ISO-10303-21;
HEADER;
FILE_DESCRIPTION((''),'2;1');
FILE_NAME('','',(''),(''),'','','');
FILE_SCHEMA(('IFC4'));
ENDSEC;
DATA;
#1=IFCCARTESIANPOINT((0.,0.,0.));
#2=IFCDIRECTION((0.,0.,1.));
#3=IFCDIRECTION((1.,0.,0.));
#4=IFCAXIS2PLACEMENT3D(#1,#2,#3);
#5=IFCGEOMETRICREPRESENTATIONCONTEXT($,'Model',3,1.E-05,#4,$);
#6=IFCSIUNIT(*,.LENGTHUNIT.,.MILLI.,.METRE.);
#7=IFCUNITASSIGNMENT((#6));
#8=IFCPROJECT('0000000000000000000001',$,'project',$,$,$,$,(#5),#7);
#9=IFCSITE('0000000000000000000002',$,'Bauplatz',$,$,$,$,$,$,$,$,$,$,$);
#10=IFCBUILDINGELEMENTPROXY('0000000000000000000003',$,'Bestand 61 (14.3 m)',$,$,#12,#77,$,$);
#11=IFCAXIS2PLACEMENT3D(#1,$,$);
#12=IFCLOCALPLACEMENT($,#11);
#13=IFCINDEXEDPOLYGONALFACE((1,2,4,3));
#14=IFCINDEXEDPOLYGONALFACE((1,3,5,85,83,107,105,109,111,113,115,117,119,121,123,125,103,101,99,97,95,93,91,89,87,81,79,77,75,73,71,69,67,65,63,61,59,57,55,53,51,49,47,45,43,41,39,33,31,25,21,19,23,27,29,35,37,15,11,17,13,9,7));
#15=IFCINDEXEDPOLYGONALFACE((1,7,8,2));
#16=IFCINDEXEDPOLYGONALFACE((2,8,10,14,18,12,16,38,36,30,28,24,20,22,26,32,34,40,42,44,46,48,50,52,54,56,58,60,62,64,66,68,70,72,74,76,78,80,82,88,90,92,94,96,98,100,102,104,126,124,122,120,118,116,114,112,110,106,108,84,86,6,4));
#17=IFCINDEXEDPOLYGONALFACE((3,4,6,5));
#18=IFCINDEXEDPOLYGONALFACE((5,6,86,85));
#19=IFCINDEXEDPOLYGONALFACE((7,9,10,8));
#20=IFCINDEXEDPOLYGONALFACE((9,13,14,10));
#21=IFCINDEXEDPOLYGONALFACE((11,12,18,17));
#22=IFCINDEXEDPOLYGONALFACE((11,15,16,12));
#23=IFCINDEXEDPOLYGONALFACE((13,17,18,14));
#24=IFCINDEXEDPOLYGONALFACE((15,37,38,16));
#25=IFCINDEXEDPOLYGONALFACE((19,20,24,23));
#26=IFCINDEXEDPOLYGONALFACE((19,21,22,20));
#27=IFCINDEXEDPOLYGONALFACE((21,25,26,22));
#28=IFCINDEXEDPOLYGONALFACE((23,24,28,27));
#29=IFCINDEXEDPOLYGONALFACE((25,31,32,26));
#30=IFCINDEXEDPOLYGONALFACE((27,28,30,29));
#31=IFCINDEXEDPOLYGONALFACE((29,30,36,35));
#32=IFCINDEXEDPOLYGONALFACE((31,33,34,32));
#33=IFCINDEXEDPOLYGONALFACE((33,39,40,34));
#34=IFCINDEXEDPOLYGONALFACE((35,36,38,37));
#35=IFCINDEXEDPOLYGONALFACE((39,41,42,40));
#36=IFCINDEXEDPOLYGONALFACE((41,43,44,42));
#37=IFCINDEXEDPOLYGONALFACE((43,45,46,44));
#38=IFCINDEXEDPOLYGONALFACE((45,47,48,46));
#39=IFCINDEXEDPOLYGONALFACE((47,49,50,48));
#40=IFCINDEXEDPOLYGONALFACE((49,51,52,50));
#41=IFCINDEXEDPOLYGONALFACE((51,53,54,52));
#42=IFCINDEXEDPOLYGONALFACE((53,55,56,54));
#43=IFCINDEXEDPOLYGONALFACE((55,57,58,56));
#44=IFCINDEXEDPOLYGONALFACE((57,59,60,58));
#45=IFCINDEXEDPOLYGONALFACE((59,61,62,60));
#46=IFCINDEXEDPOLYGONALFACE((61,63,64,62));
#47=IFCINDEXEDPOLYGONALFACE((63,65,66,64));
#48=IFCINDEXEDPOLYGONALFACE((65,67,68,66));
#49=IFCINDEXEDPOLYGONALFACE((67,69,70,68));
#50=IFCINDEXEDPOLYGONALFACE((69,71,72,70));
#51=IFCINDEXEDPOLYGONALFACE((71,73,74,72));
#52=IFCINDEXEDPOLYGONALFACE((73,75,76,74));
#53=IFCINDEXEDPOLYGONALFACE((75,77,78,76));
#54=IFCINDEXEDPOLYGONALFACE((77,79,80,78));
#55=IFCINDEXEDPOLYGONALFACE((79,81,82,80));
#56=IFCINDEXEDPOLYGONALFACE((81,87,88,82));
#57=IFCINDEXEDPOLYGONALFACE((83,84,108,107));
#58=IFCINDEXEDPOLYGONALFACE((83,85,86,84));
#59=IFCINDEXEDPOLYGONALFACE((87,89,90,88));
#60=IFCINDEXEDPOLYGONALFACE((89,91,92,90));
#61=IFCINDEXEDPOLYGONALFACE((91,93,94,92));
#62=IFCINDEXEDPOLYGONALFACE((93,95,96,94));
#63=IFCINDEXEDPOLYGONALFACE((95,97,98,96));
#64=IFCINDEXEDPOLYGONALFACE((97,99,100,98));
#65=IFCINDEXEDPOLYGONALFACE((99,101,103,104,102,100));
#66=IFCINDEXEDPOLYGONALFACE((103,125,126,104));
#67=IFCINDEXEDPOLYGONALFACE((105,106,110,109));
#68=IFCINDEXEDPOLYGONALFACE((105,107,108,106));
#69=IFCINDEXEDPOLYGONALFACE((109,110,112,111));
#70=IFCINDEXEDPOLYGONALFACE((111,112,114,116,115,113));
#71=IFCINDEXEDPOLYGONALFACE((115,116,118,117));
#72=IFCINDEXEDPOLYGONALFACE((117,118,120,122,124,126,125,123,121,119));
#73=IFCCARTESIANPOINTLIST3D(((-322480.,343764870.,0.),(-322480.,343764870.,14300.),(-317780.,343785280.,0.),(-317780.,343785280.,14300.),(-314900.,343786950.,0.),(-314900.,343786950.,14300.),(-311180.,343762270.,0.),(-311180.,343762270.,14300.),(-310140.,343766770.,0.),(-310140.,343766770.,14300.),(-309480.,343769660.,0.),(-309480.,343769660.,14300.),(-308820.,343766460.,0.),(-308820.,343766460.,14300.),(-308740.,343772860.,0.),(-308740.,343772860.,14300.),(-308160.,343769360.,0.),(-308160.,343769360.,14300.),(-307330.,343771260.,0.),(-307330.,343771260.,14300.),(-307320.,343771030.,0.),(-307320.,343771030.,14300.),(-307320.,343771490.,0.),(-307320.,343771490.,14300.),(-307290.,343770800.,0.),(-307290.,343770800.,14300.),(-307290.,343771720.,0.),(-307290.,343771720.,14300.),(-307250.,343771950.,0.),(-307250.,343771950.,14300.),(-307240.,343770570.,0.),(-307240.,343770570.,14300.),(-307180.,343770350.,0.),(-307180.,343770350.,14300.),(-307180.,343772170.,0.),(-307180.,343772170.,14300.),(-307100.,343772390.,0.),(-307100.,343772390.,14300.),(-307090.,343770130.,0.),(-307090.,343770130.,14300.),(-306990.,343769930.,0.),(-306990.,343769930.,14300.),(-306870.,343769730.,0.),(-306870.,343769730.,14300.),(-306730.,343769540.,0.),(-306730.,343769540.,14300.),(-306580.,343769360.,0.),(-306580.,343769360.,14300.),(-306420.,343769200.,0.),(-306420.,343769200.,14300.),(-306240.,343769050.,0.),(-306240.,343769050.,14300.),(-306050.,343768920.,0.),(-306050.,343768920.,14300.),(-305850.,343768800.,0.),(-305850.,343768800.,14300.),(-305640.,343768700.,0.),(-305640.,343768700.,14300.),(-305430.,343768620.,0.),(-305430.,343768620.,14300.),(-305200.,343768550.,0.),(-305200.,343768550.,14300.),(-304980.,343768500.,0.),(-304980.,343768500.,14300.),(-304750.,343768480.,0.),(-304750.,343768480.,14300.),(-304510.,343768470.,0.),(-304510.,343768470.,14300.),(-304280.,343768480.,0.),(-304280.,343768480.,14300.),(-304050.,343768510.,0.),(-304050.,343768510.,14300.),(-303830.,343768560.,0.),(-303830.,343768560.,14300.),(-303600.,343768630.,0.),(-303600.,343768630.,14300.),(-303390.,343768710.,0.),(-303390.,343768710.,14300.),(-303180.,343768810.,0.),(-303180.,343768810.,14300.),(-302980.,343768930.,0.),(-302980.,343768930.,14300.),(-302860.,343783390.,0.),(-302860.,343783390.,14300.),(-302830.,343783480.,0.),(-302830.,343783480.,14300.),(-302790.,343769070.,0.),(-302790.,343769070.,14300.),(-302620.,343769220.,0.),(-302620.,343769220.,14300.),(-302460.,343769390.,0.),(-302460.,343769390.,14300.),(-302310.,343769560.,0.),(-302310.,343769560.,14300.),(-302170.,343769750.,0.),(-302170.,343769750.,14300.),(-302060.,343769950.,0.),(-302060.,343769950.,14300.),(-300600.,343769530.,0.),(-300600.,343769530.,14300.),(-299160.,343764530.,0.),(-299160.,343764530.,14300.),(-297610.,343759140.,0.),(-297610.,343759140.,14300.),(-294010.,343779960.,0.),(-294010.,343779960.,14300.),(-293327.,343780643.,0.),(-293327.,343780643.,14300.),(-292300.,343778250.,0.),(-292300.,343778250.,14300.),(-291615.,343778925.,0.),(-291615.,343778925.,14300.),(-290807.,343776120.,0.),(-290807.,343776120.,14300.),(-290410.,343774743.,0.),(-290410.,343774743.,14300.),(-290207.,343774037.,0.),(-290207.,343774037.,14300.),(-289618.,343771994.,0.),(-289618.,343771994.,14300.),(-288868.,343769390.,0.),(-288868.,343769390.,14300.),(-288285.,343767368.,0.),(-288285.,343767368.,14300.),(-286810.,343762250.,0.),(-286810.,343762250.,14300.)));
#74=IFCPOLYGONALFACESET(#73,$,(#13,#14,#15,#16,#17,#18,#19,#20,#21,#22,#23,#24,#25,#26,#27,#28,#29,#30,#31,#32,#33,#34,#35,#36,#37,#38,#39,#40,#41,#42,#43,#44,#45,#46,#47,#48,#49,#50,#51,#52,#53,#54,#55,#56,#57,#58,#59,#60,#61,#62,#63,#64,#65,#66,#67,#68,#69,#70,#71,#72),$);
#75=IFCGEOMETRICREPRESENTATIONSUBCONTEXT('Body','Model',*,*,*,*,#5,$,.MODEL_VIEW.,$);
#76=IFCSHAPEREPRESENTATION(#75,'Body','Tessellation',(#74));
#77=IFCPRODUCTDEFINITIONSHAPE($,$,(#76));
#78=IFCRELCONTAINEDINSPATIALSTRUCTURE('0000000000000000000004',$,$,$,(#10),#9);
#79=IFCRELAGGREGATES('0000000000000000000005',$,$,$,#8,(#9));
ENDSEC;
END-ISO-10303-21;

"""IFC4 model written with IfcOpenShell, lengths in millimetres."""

from ifc_helpers import new_model, si_unit, origin_with_axes, place, context, subcontext, project, spatial, indexed_curve, outline, extrude, element, save


model = new_model("IFC4")

# Units and contexts
model_context = context("Model", 3, precision=1e-05, world=origin_with_axes())
body_context = subcontext(model_context, "Body", "Model", "MODEL_VIEW")
ifc_project = project(units=[si_unit("LENGTHUNIT", "METRE", prefix="MILLI")], contexts=[model_context])

# Site
site = spatial("IfcSite", under=ifc_project, Name="Bauplatz")

# Building element proxy
proxy_1_placement = place(None, origin_with_axes())
element("IfcBuildingElementProxy", 1, at=proxy_1_placement, inside=site, Name="Bestand 61 (14.3 m)", context=body_context, shape_type="SweptSolid", body=[
    extrude(outline(indexed_curve([(-302830.0, 343783480.0), (-314900.0, 343786950.0), (-317780.0, 343785280.0), (-322480.0, 343764870.0), (-311180.0, 343762270.0), (-310140.0, 343766770.0), (-308820.0, 343766460.0), (-308160.0, 343769360.0), (-309480.0, 343769660.0), (-308740.0, 343772860.0), (-307100.0, 343772390.0), (-307180.0, 343772170.0), (-307250.0, 343771950.0), (-307290.0, 343771720.0), (-307320.0, 343771490.0), (-307330.0, 343771260.0), (-307320.0, 343771030.0), (-307290.0, 343770800.0), (-307240.0, 343770570.0), (-307180.0, 343770350.0), (-307090.0, 343770130.0), (-306990.0, 343769930.0), (-306870.0, 343769730.0), (-306730.0, 343769540.0), (-306580.0, 343769360.0), (-306420.0, 343769200.0), (-306240.0, 343769050.0), (-306050.0, 343768920.0), (-305850.0, 343768800.0), (-305640.0, 343768700.0), (-305430.0, 343768620.0), (-305200.0, 343768550.0), (-304980.0, 343768500.0), (-304750.0, 343768480.0), (-304510.0, 343768470.0), (-304280.0, 343768480.0), (-304050.0, 343768510.0), (-303830.0, 343768560.0), (-303600.0, 343768630.0), (-303390.0, 343768710.0), (-303180.0, 343768810.0), (-302980.0, 343768930.0), (-302790.0, 343769070.0), (-302620.0, 343769220.0), (-302460.0, 343769390.0), (-302310.0, 343769560.0), (-302170.0, 343769750.0), (-302060.0, 343769950.0), (-300600.0, 343769530.0), (-299160.0, 343764530.0), (-297610.0, 343759140.0), (-286810.0, 343762250.0), (-288285.0, 343767368.0), (-288868.0, 343769390.0), (-289618.0, 343771994.0), (-290207.0, 343774037.0), (-290410.0, 343774743.0), (-290807.0, 343776120.0), (-291615.0, 343778925.0), (-292300.0, 343778250.0), (-294010.0, 343779960.0), (-293327.0, 343780643.0), (-302860.0, 343783390.0)])), None, (0.0, 0.0, 1.0), 14300.0),
])

save(model, "model.ifc")
